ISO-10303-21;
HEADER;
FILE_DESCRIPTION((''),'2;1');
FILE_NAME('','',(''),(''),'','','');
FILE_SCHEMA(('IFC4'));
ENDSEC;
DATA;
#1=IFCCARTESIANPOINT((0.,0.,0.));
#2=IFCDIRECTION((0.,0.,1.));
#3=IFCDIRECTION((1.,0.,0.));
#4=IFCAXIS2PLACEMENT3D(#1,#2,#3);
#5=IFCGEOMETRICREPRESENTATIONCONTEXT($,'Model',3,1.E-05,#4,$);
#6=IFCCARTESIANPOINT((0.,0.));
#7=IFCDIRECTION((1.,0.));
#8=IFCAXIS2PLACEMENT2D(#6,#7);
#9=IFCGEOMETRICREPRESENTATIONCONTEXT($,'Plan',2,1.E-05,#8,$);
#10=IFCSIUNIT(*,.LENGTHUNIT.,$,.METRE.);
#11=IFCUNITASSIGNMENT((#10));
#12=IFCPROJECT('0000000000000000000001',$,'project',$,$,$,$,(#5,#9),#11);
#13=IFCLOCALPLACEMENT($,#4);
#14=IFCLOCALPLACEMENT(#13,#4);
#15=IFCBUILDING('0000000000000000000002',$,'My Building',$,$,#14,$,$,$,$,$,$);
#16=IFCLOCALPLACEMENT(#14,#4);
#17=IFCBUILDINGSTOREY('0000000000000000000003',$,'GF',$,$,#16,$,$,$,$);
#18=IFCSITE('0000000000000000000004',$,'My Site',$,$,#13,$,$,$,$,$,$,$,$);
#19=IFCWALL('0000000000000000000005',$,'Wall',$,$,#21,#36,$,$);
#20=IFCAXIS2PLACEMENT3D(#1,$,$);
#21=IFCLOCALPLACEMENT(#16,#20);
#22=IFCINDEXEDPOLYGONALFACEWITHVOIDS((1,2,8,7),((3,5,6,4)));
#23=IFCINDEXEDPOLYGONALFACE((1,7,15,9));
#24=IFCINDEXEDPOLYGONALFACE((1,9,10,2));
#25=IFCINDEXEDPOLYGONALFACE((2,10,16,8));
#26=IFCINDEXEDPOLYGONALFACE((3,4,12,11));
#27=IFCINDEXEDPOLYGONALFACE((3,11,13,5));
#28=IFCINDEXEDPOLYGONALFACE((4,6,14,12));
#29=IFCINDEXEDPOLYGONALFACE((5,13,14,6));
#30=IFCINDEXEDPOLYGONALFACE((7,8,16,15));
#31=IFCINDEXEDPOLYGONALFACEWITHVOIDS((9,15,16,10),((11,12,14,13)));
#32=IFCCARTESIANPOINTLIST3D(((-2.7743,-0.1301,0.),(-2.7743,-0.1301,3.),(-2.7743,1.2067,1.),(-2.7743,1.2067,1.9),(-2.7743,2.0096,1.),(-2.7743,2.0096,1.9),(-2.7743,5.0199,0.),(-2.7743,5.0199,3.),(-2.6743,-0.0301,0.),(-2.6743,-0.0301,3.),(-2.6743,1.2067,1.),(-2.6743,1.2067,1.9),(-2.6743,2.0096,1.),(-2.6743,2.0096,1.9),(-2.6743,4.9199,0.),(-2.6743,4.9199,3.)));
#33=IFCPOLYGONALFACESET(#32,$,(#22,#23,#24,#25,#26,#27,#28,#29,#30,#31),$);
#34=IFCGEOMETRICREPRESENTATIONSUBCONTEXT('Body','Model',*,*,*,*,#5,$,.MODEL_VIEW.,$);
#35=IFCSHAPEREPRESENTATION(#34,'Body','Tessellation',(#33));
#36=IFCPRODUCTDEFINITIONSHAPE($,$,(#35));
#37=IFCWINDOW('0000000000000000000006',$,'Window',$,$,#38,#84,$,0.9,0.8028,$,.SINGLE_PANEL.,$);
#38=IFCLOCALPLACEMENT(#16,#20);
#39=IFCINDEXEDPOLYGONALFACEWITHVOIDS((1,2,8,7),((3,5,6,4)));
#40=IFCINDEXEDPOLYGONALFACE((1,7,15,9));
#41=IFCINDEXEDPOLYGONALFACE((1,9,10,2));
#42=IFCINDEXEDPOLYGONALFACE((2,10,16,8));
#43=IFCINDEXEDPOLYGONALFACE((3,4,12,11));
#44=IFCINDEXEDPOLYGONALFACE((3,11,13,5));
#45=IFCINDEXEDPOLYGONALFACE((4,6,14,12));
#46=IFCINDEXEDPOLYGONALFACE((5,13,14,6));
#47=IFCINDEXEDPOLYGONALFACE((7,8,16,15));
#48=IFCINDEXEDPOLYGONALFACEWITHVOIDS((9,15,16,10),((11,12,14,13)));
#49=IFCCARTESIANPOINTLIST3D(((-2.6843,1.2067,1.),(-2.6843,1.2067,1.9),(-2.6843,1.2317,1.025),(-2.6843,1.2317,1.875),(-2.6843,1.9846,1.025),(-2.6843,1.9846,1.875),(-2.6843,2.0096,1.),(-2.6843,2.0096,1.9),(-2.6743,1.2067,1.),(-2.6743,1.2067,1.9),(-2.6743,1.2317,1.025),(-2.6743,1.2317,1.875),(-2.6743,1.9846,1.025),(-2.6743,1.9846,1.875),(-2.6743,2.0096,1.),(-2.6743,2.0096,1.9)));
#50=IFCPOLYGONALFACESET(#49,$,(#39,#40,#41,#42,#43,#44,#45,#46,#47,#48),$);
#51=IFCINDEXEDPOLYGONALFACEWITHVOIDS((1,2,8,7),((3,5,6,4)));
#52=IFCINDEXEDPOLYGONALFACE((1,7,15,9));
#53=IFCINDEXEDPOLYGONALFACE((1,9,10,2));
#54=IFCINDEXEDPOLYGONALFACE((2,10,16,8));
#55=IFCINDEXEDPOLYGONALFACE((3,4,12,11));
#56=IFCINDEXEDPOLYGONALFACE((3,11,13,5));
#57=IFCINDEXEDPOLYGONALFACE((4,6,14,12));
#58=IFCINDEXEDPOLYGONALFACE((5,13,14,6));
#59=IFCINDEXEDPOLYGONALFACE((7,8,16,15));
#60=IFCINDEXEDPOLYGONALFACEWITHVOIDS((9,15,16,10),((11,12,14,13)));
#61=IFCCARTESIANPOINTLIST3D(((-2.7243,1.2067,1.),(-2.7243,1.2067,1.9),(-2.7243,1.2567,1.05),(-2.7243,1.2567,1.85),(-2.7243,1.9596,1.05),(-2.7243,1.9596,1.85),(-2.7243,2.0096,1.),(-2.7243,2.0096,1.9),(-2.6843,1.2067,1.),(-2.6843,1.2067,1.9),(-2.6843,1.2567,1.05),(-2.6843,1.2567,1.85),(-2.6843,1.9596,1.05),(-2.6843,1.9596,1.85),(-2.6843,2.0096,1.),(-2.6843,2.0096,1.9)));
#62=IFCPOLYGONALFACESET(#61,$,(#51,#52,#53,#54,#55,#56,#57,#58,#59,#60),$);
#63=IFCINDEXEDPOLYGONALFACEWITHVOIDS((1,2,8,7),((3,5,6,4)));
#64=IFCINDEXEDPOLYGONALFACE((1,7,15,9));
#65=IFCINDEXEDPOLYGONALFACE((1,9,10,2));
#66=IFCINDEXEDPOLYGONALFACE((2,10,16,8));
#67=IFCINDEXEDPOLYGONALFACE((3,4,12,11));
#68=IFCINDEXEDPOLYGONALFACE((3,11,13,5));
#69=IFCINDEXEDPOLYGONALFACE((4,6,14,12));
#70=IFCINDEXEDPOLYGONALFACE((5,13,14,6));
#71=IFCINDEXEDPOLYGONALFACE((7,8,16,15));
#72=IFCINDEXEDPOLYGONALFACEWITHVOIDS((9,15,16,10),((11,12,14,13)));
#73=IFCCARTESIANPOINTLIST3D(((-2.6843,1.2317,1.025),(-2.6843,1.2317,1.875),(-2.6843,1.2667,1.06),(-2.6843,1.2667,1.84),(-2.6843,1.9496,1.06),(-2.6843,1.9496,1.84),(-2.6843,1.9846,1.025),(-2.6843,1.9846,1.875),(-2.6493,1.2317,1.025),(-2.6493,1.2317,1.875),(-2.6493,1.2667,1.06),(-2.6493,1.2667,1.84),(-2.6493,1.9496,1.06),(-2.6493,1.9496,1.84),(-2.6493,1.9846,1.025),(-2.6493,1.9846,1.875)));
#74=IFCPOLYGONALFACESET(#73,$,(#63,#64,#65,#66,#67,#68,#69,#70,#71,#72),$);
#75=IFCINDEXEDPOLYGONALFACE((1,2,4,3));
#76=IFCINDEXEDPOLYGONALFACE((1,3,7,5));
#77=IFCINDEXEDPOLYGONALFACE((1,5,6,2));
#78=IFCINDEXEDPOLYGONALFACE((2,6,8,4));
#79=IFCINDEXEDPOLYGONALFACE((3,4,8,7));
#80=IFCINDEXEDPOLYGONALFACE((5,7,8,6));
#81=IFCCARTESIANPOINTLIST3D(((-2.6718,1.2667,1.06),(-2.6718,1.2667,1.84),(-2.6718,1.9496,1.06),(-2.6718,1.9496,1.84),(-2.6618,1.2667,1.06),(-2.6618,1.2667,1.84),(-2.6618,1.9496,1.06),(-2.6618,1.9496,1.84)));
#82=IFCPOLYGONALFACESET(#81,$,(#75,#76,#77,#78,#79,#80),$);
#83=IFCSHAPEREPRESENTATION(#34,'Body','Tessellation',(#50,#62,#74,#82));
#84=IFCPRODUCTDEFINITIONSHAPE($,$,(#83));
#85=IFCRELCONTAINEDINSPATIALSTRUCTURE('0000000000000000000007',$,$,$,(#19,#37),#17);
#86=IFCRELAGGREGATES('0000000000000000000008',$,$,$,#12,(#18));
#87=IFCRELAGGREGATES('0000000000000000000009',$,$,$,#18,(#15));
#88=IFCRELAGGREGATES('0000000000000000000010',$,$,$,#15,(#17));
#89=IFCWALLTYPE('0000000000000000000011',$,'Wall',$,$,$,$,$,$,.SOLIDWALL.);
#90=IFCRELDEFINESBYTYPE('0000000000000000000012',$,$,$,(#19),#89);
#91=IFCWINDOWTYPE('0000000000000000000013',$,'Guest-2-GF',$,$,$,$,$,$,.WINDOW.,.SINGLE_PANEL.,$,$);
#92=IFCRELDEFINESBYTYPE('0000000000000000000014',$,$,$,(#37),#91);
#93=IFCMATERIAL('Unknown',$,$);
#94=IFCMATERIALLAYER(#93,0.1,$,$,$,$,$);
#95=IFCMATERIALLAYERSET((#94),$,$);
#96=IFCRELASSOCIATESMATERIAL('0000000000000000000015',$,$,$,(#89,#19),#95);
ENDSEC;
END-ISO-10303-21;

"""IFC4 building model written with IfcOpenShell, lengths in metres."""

from ifc_helpers import new_model, entity, si_unit, frame, origin_with_axes, origin_2d_with_axis, place, context, subcontext, project, spatial, line, indexed_curve, outline, extrude, shape, source, transform, mapped, material, layer, layer_set, layer_usage, type_object, type_shapes, element, fill, save


model = new_model("IFC4")

# Units and contexts
model_context = context("Model", 3, precision=1e-05, world=origin_with_axes())
plan_context = context("Plan", 2, precision=1e-05, world=origin_2d_with_axis())
body_context_1 = subcontext(model_context, "Body", "Model", "MODEL_VIEW")
body_context_2 = subcontext(plan_context, "Body", "Plan", "PLAN_VIEW")
ifc_project = project(units=[si_unit("LENGTHUNIT", "METRE")], contexts=[model_context, plan_context])

# Site, building, storey
site_placement = place(None, origin_with_axes())
site = spatial("IfcSite", under=ifc_project, at=site_placement, Name="My Site")
building_placement = place(site_placement, origin_with_axes())
building = spatial("IfcBuilding", under=site, at=building_placement, Name="My Building")
storey_placement = place(building_placement, origin_with_axes())
storey = spatial("IfcBuildingStorey", under=building, at=storey_placement, Name="GF")

# Shared definitions
ifc_material_1 = material(Name="Unknown")

# Shared definitions
ifc_layer_1 = layer(ifc_material_1, 0.1)
ifc_layer_set_1 = layer_set([ifc_layer_1])
wall_type = type_object("IfcWallType", Name="Wall", PredefinedType="SOLIDWALL", material=ifc_layer_set_1)

# Wall, opening, window
ifc_layer_usage_1 = layer_usage(ifc_layer_set_1, "AXIS2", "POSITIVE", 0.0)
wall_1_placement = place(storey_placement, frame((-2.7743, 5.0199, 0.0), z_axis=(0.0, 0.0, 1.0), x_axis=(0.0, -1.0, 0.0)))
wall_1 = element("IfcWall", 1, at=wall_1_placement, inside=storey, type_object=wall_type, material=ifc_layer_usage_1, Name="Wall", context=body_context_1, shape_type="SweptSolid", body=[
    extrude(outline(indexed_curve([(0.0, 0.0), (0.1, 0.1), (5.05, 0.1), (5.15, 0.0)], segments=[line(1, 2, 3, 4, 1)])), origin_with_axes(), (0.0, 0.0, 1.0), 3.0),
])
shared_shape_1 = source(origin_with_axes(), body_context_1, "Body", "SweptSolid", [
    extrude(outline(indexed_curve([(0.0, 0.0), (0.8028, 0.0), (0.8028, 0.9), (0.0, 0.9)], segments=[line(1, 2, 3, 4, 1)])), frame((0.0, -0.6, 0.0), z_axis=(0.0, -1.0, 0.0), x_axis=(1.0, 0.0, 0.0)), (0.0, 0.0, -1.0), 1.2),
])
opening_1_placement = place(wall_1_placement, frame((3.0103, 0.0, 1.0), z_axis=(0.0, 0.0, 1.0), x_axis=(1.0, 0.0, 0.0)))
opening_1 = element("IfcOpeningElement", 2, at=opening_1_placement, cuts=wall_1, PredefinedType="OPENING", context=body_context_1, shape_type="MappedRepresentation", body=[
    mapped(shared_shape_1, transform((0.0, 0.0, 0.0), x_axis=(1.0, 0.0, 0.0), y_axis=(0.0, 1.0, 0.0), z_axis=(0.0, 0.0, 1.0), scale=1.0)),
])
window_type_1 = type_object("IfcWindowType", Name="Guest-2-GF", PartitioningType="SINGLE_PANEL", PredefinedType="WINDOW")
shared_shape_2 = source(origin_with_axes(), body_context_1, "Body", "SweptSolid", [
    extrude(outline(indexed_curve([(0.0, 0.0), (0.8028, 0.0), (0.8028, 0.9), (0.0, 0.9)], segments=[line(1, 2, 3, 4, 1)]), holes=[indexed_curve([(0.025, 0.025), (0.7778, 0.025), (0.7778, 0.875), (0.025, 0.875)], segments=[line(1, 2, 3, 4, 1)])]), frame((0.0, 0.09, 0.0), z_axis=(0.0, -1.0, 0.0), x_axis=(1.0, 0.0, 0.0)), (0.0, 0.0, -1.0), 0.01),
    extrude(outline(indexed_curve([(0.0, 0.0), (0.8028, 0.0), (0.8028, 0.9), (0.0, 0.9)], segments=[line(1, 2, 3, 4, 1)]), holes=[indexed_curve([(0.05, 0.05), (0.7528, 0.05), (0.7528, 0.85), (0.05, 0.85)], segments=[line(1, 2, 3, 4, 1)])]), frame((0.0, 0.05, 0.0), z_axis=(0.0, -1.0, 0.0), x_axis=(1.0, 0.0, 0.0)), (0.0, 0.0, -1.0), 0.04),
    extrude(outline(indexed_curve([(0.0, 0.0), (0.7528, 0.0), (0.7528, 0.85), (0.0, 0.85)], segments=[line(1, 2, 3, 4, 1)]), holes=[indexed_curve([(0.035, 0.035), (0.7178, 0.035), (0.7178, 0.815), (0.035, 0.815)], segments=[line(1, 2, 3, 4, 1)])]), frame((0.025, 0.09, 0.025), z_axis=(0.0, -1.0, 0.0), x_axis=(1.0, 0.0, 0.0)), (0.0, 0.0, -1.0), 0.035),
    extrude(outline(indexed_curve([(0.035, 0.035), (0.7178, 0.035), (0.7178, 0.815), (0.035, 0.815)], segments=[line(1, 2, 3, 4, 1)])), frame((0.025, 0.1025, 0.025), z_axis=(0.0, -1.0, 0.0), x_axis=(1.0, 0.0, 0.0)), (0.0, 0.0, -1.0), 0.01),
])
shared_shape_3 = source(origin_with_axes(), body_context_2, "Body", "Curve2D", [
    entity("IfcIndexedPolyCurve", entity("IfcCartesianPointList2D", [[0.05, 0.05], [0.7528, 0.05]])),
    entity("IfcIndexedPolyCurve", entity("IfcCartesianPointList2D", [[0.0, 0.1], [0.025, 0.1], [0.025, 0.09], [0.05, 0.09], [0.05, 0.05], [0.0, 0.05]]), [entity("IfcLineIndex", [1, 2, 3, 4, 5, 6, 1])]),
    entity("IfcIndexedPolyCurve", entity("IfcCartesianPointList2D", [[0.8028, 0.1], [0.7778, 0.1], [0.7778, 0.09], [0.7528, 0.09], [0.7528, 0.05], [0.8028, 0.05]]), [entity("IfcLineIndex", [1, 2, 3, 4, 5, 6, 1])]),
    entity("IfcIndexedPolyCurve", entity("IfcCartesianPointList2D", [[0.025, 0.09], [0.06, 0.09], [0.06, 0.125], [0.025, 0.125]]), [entity("IfcLineIndex", [1, 2, 3, 4, 1])]),
    entity("IfcIndexedPolyCurve", entity("IfcCartesianPointList2D", [[0.7778, 0.09], [0.7428, 0.09], [0.7428, 0.125], [0.7778, 0.125]]), [entity("IfcLineIndex", [1, 2, 3, 4, 1])]),
    entity("IfcIndexedPolyCurve", entity("IfcCartesianPointList2D", [[0.06, 0.09], [0.7428, 0.09]])),
    entity("IfcIndexedPolyCurve", entity("IfcCartesianPointList2D", [[0.06, 0.125], [0.7428, 0.125]])),
    entity("IfcIndexedPolyCurve", entity("IfcCartesianPointList2D", [[0.06, 0.1075], [0.7428, 0.1075]])),
])
type_shapes(window_type_1, [shared_shape_2, shared_shape_3])
window_1_placement = place(opening_1_placement, frame((0.0, 0.0, 0.0), z_axis=(0.0, 0.0, 1.0), x_axis=(1.0, 0.0, 0.0)))
window_1 = element("IfcWindow", 3, at=window_1_placement, inside=storey, type_object=window_type_1, Name="Window", OverallHeight=0.9, OverallWidth=0.8028, PartitioningType="SINGLE_PANEL", shapes=[
    shape(body_context_1, "Body", "MappedRepresentation", [mapped(shared_shape_2, transform((0.0, 0.0, 0.0), x_axis=(1.0, 0.0, 0.0), y_axis=(0.0, 1.0, 0.0), z_axis=(0.0, 0.0, 1.0), scale=1.0))]),
    shape(body_context_2, "Body", "MappedRepresentation", [mapped(shared_shape_3, transform((0.0, 0.0, 0.0), x_axis=(1.0, 0.0, 0.0), y_axis=(0.0, 1.0, 0.0), z_axis=(0.0, 0.0, 1.0), scale=1.0))]),
])
fill(opening_1, window_1)

save(model, "model.ifc")
